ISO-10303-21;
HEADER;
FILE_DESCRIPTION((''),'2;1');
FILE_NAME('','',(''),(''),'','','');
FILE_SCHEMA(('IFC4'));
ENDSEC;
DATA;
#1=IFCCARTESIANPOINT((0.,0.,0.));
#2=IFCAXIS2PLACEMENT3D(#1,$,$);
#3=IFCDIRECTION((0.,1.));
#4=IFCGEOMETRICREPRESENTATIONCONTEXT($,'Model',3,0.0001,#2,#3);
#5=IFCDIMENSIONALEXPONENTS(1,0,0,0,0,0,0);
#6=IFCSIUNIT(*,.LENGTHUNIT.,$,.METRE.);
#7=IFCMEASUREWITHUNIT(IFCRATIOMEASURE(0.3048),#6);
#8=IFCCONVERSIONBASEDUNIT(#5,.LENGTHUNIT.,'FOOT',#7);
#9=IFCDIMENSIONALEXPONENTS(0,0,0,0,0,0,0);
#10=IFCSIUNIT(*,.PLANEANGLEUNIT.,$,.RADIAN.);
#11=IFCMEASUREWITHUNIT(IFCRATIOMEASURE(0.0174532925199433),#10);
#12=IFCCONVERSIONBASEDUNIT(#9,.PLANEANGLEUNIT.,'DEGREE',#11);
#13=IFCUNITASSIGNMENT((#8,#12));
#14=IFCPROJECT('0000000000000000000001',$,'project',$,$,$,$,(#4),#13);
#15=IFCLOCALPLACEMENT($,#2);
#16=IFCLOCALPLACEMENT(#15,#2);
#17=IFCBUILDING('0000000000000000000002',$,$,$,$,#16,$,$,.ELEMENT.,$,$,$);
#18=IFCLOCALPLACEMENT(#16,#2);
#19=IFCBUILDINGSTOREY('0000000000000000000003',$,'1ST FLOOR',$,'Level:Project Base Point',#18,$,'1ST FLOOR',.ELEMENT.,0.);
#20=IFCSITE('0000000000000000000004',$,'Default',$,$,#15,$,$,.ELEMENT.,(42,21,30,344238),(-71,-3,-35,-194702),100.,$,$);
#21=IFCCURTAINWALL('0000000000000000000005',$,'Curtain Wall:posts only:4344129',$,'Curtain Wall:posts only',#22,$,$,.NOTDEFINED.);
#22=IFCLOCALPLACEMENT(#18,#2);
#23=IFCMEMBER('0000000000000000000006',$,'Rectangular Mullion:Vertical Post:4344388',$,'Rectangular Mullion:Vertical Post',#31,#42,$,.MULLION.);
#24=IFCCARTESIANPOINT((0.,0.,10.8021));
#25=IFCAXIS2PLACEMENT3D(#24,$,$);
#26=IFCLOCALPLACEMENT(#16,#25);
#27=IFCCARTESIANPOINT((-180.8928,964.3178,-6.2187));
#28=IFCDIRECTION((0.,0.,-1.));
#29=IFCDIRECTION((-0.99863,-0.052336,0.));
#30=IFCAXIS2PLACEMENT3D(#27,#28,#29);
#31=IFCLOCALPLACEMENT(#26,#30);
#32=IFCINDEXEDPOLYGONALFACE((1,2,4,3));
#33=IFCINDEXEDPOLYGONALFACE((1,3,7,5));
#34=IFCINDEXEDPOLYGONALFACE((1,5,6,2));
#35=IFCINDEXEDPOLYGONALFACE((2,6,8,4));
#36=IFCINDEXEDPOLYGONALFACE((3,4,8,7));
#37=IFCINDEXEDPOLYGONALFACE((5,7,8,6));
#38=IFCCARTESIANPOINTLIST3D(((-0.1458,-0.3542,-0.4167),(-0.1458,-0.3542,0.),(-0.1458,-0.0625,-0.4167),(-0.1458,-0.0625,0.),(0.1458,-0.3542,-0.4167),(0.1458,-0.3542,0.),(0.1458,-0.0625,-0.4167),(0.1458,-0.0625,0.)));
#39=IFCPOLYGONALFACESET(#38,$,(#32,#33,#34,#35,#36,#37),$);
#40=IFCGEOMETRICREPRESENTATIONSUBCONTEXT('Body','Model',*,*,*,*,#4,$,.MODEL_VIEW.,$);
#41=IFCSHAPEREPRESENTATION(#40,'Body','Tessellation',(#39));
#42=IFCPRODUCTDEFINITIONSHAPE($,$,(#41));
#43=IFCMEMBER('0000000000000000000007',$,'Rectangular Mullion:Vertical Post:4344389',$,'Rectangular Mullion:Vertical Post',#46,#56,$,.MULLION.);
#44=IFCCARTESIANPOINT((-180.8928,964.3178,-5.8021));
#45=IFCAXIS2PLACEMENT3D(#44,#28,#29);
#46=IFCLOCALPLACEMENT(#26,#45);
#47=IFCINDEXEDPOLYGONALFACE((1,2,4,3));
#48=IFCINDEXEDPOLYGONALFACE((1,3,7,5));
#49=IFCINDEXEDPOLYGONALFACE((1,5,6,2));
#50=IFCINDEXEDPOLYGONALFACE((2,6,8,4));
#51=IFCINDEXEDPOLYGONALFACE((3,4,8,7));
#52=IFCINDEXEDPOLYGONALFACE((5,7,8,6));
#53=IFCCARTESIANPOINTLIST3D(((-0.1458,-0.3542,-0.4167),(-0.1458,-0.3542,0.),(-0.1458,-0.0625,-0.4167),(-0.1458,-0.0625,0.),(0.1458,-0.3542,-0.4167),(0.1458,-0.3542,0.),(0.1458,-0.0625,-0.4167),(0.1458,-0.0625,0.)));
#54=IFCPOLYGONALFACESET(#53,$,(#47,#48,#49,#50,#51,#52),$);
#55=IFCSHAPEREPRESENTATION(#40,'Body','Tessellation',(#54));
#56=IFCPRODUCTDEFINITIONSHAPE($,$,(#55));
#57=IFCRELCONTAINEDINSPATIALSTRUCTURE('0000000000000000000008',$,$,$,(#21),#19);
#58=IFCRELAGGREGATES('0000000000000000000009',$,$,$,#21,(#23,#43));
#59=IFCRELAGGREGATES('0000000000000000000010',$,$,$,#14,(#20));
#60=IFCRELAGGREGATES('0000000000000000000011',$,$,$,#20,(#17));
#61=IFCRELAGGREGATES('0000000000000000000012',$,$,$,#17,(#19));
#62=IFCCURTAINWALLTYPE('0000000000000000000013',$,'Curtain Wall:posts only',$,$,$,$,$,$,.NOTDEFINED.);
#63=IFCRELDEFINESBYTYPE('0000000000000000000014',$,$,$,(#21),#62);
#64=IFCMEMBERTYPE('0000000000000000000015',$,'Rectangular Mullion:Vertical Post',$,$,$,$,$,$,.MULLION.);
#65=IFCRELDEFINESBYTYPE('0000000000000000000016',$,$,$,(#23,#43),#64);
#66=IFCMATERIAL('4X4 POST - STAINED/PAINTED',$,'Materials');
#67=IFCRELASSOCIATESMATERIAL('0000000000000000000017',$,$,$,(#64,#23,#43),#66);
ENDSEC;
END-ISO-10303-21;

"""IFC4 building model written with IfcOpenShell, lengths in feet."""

from ifc_helpers import new_model, entity, si_unit, converted_unit, direction, frame, origin, origin_2d_with_axis, place, context, subcontext, project, spatial, rectangle, extrude, source, transform, mapped, material, material_profile, profile_set, profile_usage, type_object, type_shapes, element, aggregate, save


model = new_model("IFC4")

# Units and contexts
model_context = context("Model", 3, precision=0.0001, world=origin(), true_north=direction((0.0, 1.0)))
body_context = subcontext(model_context, "Body", "Model", "MODEL_VIEW")
ifc_project = project(units=[converted_unit("LENGTHUNIT", "FOOT", entity("IfcRatioMeasure", 0.3048), si_unit("LENGTHUNIT", "METRE"), dimensions=[1, 0, 0, 0, 0, 0, 0]), converted_unit("PLANEANGLEUNIT", "DEGREE", entity("IfcRatioMeasure", 0.0174532925199433), si_unit("PLANEANGLEUNIT", "RADIAN"), dimensions=[0, 0, 0, 0, 0, 0, 0])], contexts=[model_context])

# Site, building, storey
site_placement = place(None, origin())
site = spatial("IfcSite", under=ifc_project, at=site_placement, Name="Default", CompositionType="ELEMENT", RefLatitude=(42, 21, 30, 344238), RefLongitude=(-71, -3, -35, -194702), RefElevation=100.0)
building_placement = place(site_placement, origin())
building = spatial("IfcBuilding", under=site, at=building_placement, CompositionType="ELEMENT")
storey_placement = place(building_placement, origin())
storey = spatial("IfcBuildingStorey", under=building, at=storey_placement, Name="1ST FLOOR", ObjectType="Level:Project Base Point", LongName="1ST FLOOR", CompositionType="ELEMENT", Elevation=0.0)

# Curtain wall, members
curtain_wall_type_1 = type_object("IfcCurtainWallType", Name="Curtain Wall:posts only", PredefinedType="NOTDEFINED")
curtain_wall_1_placement = place(storey_placement, origin())
curtain_wall_1 = element("IfcCurtainWall", 1, at=curtain_wall_1_placement, inside=storey, type_object=curtain_wall_type_1, Name="Curtain Wall:posts only:4344129", ObjectType="Curtain Wall:posts only", PredefinedType="NOTDEFINED")
ifc_material_1 = material(Name="4X4 POST - STAINED/PAINTED", Category="Materials")
ifc_material_profile_1 = material_profile(ifc_material_1, rectangle(XDim=0.2917, YDim=0.2917, at=origin_2d_with_axis()), Name="Vertical Post")
ifc_profile_set_1 = profile_set([ifc_material_profile_1], Name="Vertical Post")
placement = place(building_placement, frame((0.0, 0.0, 10.8021)))
member_type_1 = type_object("IfcMemberType", Name="Rectangular Mullion:Vertical Post", PredefinedType="MULLION", material=ifc_profile_set_1)
shared_shape_1 = source(origin(), body_context, "Body", "SweptSolid", [
    extrude(rectangle(XDim=0.2917, YDim=0.2917, at=origin_2d_with_axis()), frame((0.0, -0.2083, -0.4167), z_axis=(0.0, 0.0, 1.0), x_axis=(0.0, -1.0, 0.0)), (0.0, 0.0, 1.0), 0.4167),
])
type_shapes(member_type_1, [shared_shape_1])
ifc_profile_usage_1 = profile_usage(ifc_profile_set_1)
member_1_placement = place(placement, frame((-180.8928, 964.3178, -6.2187), z_axis=(0.0, 0.0, -1.0), x_axis=(-0.99863, -0.052336, 0.0)))
member_1 = element("IfcMember", 2, at=member_1_placement, type_object=member_type_1, material=ifc_profile_usage_1, Name="Rectangular Mullion:Vertical Post:4344388", ObjectType="Rectangular Mullion:Vertical Post", PredefinedType="MULLION", context=body_context, shape_type="MappedRepresentation", body=[
    mapped(shared_shape_1, transform((0.0, 0.0, 0.0), scale=1.0)),
])
ifc_profile_usage_2 = profile_usage(ifc_profile_set_1)
member_2_placement = place(placement, frame((-180.8928, 964.3178, -5.8021), z_axis=(0.0, 0.0, -1.0), x_axis=(-0.99863, -0.052336, 0.0)))
member_2 = element("IfcMember", 3, at=member_2_placement, type_object=member_type_1, material=ifc_profile_usage_2, Name="Rectangular Mullion:Vertical Post:4344389", ObjectType="Rectangular Mullion:Vertical Post", PredefinedType="MULLION", context=body_context, shape_type="MappedRepresentation", body=[
    mapped(shared_shape_1, transform((0.0, 0.0, 0.0), scale=1.0)),
])
aggregate(curtain_wall_1, [member_1, member_2])

save(model, "model.ifc")
